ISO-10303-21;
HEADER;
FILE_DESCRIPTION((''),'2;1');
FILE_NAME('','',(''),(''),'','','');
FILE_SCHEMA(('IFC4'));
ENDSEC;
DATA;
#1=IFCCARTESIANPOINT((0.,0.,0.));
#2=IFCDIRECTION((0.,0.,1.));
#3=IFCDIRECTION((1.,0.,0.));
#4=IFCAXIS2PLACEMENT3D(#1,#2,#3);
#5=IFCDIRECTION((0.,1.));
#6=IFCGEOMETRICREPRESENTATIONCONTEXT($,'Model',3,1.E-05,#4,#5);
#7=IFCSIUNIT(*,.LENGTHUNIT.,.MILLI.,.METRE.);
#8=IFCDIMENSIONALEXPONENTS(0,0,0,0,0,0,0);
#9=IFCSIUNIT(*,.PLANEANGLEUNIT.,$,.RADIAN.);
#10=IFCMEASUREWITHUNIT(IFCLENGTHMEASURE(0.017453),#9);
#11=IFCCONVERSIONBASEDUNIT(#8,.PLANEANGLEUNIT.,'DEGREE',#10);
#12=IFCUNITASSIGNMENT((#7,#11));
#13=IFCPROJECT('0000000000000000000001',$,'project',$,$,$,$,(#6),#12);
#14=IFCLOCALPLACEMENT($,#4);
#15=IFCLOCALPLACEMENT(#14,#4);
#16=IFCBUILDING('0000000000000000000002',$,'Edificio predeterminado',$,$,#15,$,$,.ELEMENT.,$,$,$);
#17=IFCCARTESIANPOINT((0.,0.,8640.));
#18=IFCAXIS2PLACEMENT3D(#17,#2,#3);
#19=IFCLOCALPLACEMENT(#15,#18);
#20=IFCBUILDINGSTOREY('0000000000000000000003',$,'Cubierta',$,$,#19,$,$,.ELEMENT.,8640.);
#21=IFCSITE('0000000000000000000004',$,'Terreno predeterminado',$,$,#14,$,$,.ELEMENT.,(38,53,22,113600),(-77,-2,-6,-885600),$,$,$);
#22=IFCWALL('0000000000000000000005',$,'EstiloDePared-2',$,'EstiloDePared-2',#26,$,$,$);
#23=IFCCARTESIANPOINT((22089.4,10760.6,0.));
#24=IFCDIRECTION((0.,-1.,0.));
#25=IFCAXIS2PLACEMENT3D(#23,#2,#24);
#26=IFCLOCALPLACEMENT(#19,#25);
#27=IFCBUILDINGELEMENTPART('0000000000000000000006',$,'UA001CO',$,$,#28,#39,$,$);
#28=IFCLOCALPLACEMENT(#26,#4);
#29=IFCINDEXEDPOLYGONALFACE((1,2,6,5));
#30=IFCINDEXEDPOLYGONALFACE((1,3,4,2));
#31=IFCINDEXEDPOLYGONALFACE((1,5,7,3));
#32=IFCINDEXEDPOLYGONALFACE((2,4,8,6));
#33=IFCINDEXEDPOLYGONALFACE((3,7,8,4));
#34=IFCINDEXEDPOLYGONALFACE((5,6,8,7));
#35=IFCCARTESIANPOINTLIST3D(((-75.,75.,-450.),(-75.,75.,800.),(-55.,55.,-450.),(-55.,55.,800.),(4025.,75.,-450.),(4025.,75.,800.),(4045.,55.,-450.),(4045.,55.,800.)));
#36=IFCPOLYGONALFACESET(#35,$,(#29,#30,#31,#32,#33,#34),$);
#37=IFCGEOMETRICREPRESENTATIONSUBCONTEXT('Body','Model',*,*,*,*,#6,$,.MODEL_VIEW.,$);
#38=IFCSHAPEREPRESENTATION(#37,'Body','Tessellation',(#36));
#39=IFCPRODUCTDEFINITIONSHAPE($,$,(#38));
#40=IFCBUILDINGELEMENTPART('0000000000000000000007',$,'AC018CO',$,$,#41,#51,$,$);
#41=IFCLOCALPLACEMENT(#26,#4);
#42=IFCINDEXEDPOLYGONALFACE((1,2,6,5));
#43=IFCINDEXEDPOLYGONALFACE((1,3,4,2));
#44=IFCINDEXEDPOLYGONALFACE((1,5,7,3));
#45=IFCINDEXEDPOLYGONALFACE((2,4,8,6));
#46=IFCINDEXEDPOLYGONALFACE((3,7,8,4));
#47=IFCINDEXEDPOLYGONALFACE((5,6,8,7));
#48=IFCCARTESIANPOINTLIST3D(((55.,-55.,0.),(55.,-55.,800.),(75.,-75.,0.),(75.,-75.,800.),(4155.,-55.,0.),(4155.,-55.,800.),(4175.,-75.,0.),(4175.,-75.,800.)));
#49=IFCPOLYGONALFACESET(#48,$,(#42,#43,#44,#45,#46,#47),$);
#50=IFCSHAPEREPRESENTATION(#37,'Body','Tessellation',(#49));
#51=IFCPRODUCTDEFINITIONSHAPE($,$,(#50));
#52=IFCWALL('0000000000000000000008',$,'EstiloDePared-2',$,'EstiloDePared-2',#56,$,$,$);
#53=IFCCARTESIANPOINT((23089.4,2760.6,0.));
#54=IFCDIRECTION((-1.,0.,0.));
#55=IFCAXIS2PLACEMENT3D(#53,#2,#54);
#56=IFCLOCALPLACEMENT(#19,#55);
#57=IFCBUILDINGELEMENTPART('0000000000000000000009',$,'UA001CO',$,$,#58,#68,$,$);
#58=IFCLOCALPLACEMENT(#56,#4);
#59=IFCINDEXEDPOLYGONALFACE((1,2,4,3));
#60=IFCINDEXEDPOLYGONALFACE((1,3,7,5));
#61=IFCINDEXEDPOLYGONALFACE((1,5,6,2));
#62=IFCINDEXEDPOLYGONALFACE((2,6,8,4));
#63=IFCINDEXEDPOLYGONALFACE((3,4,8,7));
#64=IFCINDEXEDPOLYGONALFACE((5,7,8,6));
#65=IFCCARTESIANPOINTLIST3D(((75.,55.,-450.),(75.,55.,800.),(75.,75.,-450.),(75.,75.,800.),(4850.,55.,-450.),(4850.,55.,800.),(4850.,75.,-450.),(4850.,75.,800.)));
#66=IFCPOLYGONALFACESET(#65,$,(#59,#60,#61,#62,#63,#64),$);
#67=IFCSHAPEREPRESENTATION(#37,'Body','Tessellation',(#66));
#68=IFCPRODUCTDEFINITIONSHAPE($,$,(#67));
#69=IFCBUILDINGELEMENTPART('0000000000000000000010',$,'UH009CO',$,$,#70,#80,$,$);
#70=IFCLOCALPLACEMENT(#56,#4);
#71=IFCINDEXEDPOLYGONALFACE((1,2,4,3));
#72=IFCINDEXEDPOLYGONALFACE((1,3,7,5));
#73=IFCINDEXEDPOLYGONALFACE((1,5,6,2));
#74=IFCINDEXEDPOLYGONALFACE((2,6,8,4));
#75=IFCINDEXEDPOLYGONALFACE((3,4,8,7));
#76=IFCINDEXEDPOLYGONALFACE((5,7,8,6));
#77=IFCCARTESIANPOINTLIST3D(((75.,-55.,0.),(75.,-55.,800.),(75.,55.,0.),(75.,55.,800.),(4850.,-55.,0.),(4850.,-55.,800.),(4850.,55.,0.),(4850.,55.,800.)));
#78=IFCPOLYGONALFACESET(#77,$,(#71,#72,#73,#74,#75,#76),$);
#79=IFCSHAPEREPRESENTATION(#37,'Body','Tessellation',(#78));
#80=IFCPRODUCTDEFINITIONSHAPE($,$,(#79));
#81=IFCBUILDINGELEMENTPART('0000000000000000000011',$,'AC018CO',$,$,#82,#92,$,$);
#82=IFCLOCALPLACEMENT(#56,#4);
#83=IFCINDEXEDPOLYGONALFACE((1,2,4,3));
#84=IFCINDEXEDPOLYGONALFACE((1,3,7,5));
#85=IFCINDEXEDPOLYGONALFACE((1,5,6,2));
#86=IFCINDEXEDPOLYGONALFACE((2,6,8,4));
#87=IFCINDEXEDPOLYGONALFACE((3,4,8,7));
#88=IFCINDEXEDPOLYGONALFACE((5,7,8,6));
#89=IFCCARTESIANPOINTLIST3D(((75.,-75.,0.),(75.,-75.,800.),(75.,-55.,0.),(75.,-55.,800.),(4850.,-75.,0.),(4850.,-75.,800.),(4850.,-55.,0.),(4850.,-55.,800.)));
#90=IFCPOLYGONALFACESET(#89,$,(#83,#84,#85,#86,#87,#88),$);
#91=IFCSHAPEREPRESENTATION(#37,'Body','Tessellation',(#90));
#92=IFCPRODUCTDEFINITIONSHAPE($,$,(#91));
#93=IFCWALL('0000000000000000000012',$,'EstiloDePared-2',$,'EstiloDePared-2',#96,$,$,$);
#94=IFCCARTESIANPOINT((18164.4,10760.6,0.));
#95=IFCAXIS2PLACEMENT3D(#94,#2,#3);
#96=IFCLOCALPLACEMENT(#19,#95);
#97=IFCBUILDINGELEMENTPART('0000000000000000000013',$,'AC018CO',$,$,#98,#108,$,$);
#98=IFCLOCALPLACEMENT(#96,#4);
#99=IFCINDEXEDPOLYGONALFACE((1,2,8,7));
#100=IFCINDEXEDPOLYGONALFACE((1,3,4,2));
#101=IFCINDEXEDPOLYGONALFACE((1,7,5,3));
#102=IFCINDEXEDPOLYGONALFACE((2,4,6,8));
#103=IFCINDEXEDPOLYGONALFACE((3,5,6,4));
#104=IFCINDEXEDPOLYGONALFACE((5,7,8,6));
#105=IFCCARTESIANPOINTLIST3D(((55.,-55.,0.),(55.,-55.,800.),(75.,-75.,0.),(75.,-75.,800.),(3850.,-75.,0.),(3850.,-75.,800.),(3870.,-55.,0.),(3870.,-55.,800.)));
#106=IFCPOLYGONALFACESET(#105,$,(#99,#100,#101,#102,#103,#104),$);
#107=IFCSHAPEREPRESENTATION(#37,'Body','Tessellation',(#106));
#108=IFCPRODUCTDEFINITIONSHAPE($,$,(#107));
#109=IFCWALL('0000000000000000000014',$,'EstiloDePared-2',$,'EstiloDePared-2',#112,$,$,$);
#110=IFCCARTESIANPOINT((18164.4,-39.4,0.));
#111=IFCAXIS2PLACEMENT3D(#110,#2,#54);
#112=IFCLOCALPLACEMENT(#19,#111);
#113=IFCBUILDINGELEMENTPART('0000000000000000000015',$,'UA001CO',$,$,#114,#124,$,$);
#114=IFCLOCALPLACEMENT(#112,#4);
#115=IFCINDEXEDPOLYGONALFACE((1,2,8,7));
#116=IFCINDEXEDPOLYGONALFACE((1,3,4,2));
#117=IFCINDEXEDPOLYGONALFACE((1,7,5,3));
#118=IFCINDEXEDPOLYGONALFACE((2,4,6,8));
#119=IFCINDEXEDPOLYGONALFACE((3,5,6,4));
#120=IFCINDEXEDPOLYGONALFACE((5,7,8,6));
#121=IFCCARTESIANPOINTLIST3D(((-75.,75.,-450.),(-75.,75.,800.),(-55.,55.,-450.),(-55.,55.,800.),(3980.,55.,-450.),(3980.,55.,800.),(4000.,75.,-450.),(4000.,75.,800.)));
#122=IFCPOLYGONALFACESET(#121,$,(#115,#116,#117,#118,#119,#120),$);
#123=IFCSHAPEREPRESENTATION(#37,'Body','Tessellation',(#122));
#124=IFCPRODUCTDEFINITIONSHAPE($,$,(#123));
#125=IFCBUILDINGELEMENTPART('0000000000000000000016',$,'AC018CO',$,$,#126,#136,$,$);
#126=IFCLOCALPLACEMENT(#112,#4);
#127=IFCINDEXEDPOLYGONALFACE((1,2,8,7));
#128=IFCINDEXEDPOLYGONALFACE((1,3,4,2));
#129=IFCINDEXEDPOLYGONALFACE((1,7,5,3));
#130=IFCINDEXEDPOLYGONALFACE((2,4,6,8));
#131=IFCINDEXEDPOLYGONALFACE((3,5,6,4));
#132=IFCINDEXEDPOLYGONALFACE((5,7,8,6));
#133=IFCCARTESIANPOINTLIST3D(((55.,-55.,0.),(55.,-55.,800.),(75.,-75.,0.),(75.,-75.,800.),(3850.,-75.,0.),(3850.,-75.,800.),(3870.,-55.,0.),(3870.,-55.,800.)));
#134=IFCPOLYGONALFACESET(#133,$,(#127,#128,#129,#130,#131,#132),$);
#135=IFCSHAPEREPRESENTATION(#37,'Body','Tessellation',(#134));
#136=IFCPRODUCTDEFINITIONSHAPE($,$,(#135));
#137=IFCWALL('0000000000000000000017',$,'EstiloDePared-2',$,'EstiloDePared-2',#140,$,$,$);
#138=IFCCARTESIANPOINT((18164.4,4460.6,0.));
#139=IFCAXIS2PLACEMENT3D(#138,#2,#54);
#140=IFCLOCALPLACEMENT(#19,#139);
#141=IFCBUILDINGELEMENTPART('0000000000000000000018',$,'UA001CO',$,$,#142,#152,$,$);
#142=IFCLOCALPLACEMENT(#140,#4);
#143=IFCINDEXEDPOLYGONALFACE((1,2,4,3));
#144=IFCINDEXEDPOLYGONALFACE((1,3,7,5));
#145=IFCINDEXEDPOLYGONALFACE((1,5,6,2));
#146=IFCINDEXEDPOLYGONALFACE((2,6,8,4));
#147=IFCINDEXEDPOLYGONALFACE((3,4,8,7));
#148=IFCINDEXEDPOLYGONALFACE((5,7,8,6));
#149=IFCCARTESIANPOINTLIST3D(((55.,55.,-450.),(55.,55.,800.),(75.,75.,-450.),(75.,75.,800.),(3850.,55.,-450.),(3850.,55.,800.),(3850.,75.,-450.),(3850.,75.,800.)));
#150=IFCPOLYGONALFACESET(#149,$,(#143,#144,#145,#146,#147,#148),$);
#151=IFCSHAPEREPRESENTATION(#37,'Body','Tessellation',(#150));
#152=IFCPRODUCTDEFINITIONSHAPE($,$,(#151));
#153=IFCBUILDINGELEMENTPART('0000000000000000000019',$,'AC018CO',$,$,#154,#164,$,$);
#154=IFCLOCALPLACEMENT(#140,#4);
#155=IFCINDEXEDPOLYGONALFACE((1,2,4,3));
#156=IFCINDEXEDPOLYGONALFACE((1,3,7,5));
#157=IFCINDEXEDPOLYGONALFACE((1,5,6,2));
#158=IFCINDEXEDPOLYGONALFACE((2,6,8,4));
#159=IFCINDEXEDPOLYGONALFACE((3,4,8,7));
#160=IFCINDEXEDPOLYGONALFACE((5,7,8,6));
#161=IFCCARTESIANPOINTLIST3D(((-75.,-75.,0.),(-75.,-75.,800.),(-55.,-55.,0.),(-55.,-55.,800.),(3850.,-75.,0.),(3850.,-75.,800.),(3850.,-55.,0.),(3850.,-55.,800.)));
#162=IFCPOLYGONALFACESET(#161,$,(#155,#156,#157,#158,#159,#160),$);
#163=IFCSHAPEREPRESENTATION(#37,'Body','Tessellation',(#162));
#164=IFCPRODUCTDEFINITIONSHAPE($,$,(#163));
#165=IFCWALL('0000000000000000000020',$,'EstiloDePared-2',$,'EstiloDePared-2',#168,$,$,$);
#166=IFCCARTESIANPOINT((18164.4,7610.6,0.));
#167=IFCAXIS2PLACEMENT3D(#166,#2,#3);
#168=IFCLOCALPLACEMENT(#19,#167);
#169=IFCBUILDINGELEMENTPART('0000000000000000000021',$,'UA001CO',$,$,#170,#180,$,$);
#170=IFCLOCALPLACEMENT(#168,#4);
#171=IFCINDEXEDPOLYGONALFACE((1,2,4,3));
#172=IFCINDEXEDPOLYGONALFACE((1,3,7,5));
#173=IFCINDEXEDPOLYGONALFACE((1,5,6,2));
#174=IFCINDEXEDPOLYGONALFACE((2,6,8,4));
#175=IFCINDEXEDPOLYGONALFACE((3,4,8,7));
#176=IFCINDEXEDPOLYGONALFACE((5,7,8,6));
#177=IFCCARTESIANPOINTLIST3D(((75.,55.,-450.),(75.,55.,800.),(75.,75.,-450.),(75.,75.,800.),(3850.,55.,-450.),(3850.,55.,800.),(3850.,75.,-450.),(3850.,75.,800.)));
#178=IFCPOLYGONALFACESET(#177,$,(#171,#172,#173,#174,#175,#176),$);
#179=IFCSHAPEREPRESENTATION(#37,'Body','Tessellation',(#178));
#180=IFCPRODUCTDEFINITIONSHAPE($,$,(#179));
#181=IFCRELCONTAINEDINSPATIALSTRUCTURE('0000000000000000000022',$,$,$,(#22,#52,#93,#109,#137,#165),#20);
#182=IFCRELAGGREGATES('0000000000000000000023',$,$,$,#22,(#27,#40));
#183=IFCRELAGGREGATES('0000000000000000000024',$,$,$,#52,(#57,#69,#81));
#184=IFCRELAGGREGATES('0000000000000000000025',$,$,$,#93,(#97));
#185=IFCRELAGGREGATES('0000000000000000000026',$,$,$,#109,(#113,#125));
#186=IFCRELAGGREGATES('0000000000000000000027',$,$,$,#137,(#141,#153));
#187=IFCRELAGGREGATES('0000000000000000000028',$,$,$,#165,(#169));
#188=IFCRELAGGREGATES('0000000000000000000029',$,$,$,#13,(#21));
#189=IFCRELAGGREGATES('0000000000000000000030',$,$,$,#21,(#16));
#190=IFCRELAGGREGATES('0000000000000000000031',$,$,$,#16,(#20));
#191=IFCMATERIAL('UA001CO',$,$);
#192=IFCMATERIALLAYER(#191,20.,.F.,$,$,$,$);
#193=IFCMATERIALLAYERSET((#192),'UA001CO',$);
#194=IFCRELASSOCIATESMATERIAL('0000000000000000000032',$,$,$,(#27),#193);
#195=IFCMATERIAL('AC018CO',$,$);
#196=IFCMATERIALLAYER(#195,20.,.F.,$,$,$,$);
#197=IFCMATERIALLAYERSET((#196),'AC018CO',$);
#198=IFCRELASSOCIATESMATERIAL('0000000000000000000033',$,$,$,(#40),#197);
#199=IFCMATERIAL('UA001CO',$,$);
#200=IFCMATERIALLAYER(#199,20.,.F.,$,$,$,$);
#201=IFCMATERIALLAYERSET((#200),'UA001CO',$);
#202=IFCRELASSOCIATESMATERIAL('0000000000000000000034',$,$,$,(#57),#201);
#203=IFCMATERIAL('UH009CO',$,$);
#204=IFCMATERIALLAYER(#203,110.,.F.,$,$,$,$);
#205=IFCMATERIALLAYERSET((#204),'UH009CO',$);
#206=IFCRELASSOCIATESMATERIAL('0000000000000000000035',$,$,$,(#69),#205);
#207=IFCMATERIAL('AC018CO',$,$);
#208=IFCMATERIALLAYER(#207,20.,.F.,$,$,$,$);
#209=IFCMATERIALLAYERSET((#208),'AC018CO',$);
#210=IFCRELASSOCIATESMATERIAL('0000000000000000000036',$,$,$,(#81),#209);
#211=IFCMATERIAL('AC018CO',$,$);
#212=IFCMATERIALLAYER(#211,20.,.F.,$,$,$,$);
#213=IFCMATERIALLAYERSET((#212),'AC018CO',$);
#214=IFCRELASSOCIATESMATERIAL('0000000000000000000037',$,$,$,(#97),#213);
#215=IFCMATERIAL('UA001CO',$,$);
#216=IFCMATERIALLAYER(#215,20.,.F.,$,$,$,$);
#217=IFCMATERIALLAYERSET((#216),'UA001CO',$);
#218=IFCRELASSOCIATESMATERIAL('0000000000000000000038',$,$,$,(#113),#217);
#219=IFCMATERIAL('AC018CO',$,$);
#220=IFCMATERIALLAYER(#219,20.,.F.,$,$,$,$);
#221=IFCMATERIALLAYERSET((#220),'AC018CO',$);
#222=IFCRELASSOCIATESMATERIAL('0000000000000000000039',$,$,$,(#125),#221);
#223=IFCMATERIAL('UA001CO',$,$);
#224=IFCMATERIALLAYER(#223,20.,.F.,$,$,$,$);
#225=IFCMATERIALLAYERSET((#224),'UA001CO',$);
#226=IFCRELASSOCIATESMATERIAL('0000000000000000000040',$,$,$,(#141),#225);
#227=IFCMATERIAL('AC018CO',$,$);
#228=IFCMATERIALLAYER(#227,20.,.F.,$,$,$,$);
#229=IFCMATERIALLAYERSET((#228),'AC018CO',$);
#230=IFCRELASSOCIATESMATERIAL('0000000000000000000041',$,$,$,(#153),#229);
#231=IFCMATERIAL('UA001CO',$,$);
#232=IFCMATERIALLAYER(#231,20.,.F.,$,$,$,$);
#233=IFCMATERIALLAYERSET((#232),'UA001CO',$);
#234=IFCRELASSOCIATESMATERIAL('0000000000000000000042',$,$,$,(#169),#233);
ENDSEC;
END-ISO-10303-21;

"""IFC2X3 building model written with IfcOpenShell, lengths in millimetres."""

from ifc_helpers import new_model, entity, si_unit, converted_unit, direction, frame, origin_with_axes, place, context, subcontext, project, spatial, polyline, outline, extrude, material, layer, layer_set, layer_usage, element, aggregate, save


model = new_model("IFC2X3")

# Units and contexts
model_context = context("Model", 3, precision=1e-05, world=origin_with_axes(), true_north=direction((0.0, 1.0)))
body_context = subcontext(model_context, "Body", "Model", "MODEL_VIEW")
ifc_project = project(units=[si_unit("LENGTHUNIT", "METRE", prefix="MILLI"), converted_unit("PLANEANGLEUNIT", "DEGREE", entity("IfcLengthMeasure", 0.017453), si_unit("PLANEANGLEUNIT", "RADIAN"), dimensions=[0, 0, 0, 0, 0, 0, 0])], contexts=[model_context])

# Site, building, storey
site_placement = place(None, origin_with_axes())
site = spatial("IfcSite", under=ifc_project, at=site_placement, Name="Terreno predeterminado", CompositionType="ELEMENT", RefLatitude=(38, 53, 22, 113600), RefLongitude=(-77, -2, -6, -885600))
building_placement = place(site_placement, origin_with_axes())
building = spatial("IfcBuilding", under=site, at=building_placement, Name="Edificio predeterminado", CompositionType="ELEMENT")
storey_placement = place(building_placement, frame((0.0, 0.0, 8640.0), z_axis=(0.0, 0.0, 1.0), x_axis=(1.0, 0.0, 0.0)))
storey = spatial("IfcBuildingStorey", under=building, at=storey_placement, Name="Cubierta", CompositionType="ELEMENT", Elevation=8640.0)

# Walls, building element parts
wall_1_placement = place(storey_placement, frame((22089.4, 10760.6, 0.0), z_axis=(0.0, 0.0, 1.0), x_axis=(0.0, -1.0, 0.0)))
wall_1 = element("IfcWall", 1, at=wall_1_placement, inside=storey, Name="EstiloDePared-2", ObjectType="EstiloDePared-2")
ifc_material_1 = material(Name="UA001CO")
ifc_layer_1 = layer(ifc_material_1, 20.0, ventilated=False)
ifc_layer_set_1 = layer_set([ifc_layer_1], Name="UA001CO")
ifc_layer_usage_1 = layer_usage(ifc_layer_set_1, "AXIS2", "NEGATIVE", -75.0)
building_element_part_1_placement = place(wall_1_placement, origin_with_axes())
building_element_part_1 = element("IfcBuildingElementPart", 2, at=building_element_part_1_placement, material=ifc_layer_usage_1, Name="UA001CO", context=body_context, shape_type="SweptSolid", body=[
    extrude(outline(polyline([(4025.0, 75.0), (4045.0, 55.0), (-55.0, 55.0), (-75.0, 75.0), (4025.0, 75.0)])), frame((0.0, 0.0, -450.0), z_axis=(0.0, 0.0, 1.0), x_axis=(1.0, 0.0, 0.0)), (0.0, 0.0, 1.0), 1250.0),
])
ifc_material_2 = material(Name="AC018CO")
ifc_layer_2 = layer(ifc_material_2, 20.0, ventilated=False)
ifc_layer_set_2 = layer_set([ifc_layer_2], Name="AC018CO")
ifc_layer_usage_2 = layer_usage(ifc_layer_set_2, "AXIS2", "NEGATIVE", 55.0)
building_element_part_2_placement = place(wall_1_placement, origin_with_axes())
building_element_part_2 = element("IfcBuildingElementPart", 3, at=building_element_part_2_placement, material=ifc_layer_usage_2, Name="AC018CO", context=body_context, shape_type="SweptSolid", body=[
    extrude(outline(polyline([(4155.0, -55.0), (4175.0, -75.0), (75.0, -75.0), (55.0, -55.0), (4155.0, -55.0)])), origin_with_axes(), (0.0, 0.0, 1.0), 800.0),
])
aggregate(wall_1, [building_element_part_1, building_element_part_2])
wall_2_placement = place(storey_placement, frame((23089.4, 2760.6, 0.0), z_axis=(0.0, 0.0, 1.0), x_axis=(-1.0, 0.0, 0.0)))
wall_2 = element("IfcWall", 4, at=wall_2_placement, inside=storey, Name="EstiloDePared-2", ObjectType="EstiloDePared-2")
ifc_material_3 = material(Name="UA001CO")
ifc_layer_3 = layer(ifc_material_3, 20.0, ventilated=False)
ifc_layer_set_3 = layer_set([ifc_layer_3], Name="UA001CO")
ifc_layer_usage_3 = layer_usage(ifc_layer_set_3, "AXIS2", "NEGATIVE", -75.0)
building_element_part_3_placement = place(wall_2_placement, origin_with_axes())
building_element_part_3 = element("IfcBuildingElementPart", 5, at=building_element_part_3_placement, material=ifc_layer_usage_3, Name="UA001CO", context=body_context, shape_type="SweptSolid", body=[
    extrude(outline(polyline([(4850.0, 75.0), (4850.0, 55.0), (75.0, 55.0), (75.0, 75.0), (4850.0, 75.0)])), frame((0.0, 0.0, -450.0), z_axis=(0.0, 0.0, 1.0), x_axis=(1.0, 0.0, 0.0)), (0.0, 0.0, 1.0), 1250.0),
])
ifc_material_4 = material(Name="UH009CO")
ifc_layer_4 = layer(ifc_material_4, 110.0, ventilated=False)
ifc_layer_set_4 = layer_set([ifc_layer_4], Name="UH009CO")
ifc_layer_usage_4 = layer_usage(ifc_layer_set_4, "AXIS2", "NEGATIVE", -55.0)
building_element_part_4_placement = place(wall_2_placement, origin_with_axes())
building_element_part_4 = element("IfcBuildingElementPart", 6, at=building_element_part_4_placement, material=ifc_layer_usage_4, Name="UH009CO", context=body_context, shape_type="SweptSolid", body=[
    extrude(outline(polyline([(4850.0, 55.0), (4850.0, -55.0), (75.0, -55.0), (75.0, 55.0), (4850.0, 55.0)])), origin_with_axes(), (0.0, 0.0, 1.0), 800.0),
])
ifc_material_5 = material(Name="AC018CO")
ifc_layer_5 = layer(ifc_material_5, 20.0, ventilated=False)
ifc_layer_set_5 = layer_set([ifc_layer_5], Name="AC018CO")
ifc_layer_usage_5 = layer_usage(ifc_layer_set_5, "AXIS2", "NEGATIVE", 55.0)
building_element_part_5_placement = place(wall_2_placement, origin_with_axes())
building_element_part_5 = element("IfcBuildingElementPart", 7, at=building_element_part_5_placement, material=ifc_layer_usage_5, Name="AC018CO", context=body_context, shape_type="SweptSolid", body=[
    extrude(outline(polyline([(4850.0, -55.0), (4850.0, -75.0), (75.0, -75.0), (75.0, -55.0), (4850.0, -55.0)])), origin_with_axes(), (0.0, 0.0, 1.0), 800.0),
])
aggregate(wall_2, [building_element_part_3, building_element_part_4, building_element_part_5])

# Wall, building element part
wall_3_placement = place(storey_placement, frame((18164.4, 10760.6, 0.0), z_axis=(0.0, 0.0, 1.0), x_axis=(1.0, 0.0, 0.0)))
wall_3 = element("IfcWall", 8, at=wall_3_placement, inside=storey, Name="EstiloDePared-2", ObjectType="EstiloDePared-2")
ifc_material_6 = material(Name="AC018CO")
ifc_layer_6 = layer(ifc_material_6, 20.0, ventilated=False)
ifc_layer_set_6 = layer_set([ifc_layer_6], Name="AC018CO")
ifc_layer_usage_6 = layer_usage(ifc_layer_set_6, "AXIS2", "NEGATIVE", 55.0)
building_element_part_6_placement = place(wall_3_placement, origin_with_axes())
building_element_part_6 = element("IfcBuildingElementPart", 9, at=building_element_part_6_placement, material=ifc_layer_usage_6, Name="AC018CO", context=body_context, shape_type="SweptSolid", body=[
    extrude(outline(polyline([(3870.0, -55.0), (3850.0, -75.0), (75.0, -75.0), (55.0, -55.0), (3870.0, -55.0)])), origin_with_axes(), (0.0, 0.0, 1.0), 800.0),
])
aggregate(wall_3, [building_element_part_6])

# Walls, building element parts
wall_4_placement = place(storey_placement, frame((18164.4, -39.4, 0.0), z_axis=(0.0, 0.0, 1.0), x_axis=(-1.0, 0.0, 0.0)))
wall_4 = element("IfcWall", 10, at=wall_4_placement, inside=storey, Name="EstiloDePared-2", ObjectType="EstiloDePared-2")
ifc_material_7 = material(Name="UA001CO")
ifc_layer_7 = layer(ifc_material_7, 20.0, ventilated=False)
ifc_layer_set_7 = layer_set([ifc_layer_7], Name="UA001CO")
ifc_layer_usage_7 = layer_usage(ifc_layer_set_7, "AXIS2", "NEGATIVE", -75.0)
building_element_part_7_placement = place(wall_4_placement, origin_with_axes())
building_element_part_7 = element("IfcBuildingElementPart", 11, at=building_element_part_7_placement, material=ifc_layer_usage_7, Name="UA001CO", context=body_context, shape_type="SweptSolid", body=[
    extrude(outline(polyline([(4000.0, 75.0), (3980.0, 55.0), (-55.0, 55.0), (-75.0, 75.0), (4000.0, 75.0)])), frame((0.0, 0.0, -450.0), z_axis=(0.0, 0.0, 1.0), x_axis=(1.0, 0.0, 0.0)), (0.0, 0.0, 1.0), 1250.0),
])
ifc_material_8 = material(Name="AC018CO")
ifc_layer_8 = layer(ifc_material_8, 20.0, ventilated=False)
ifc_layer_set_8 = layer_set([ifc_layer_8], Name="AC018CO")
ifc_layer_usage_8 = layer_usage(ifc_layer_set_8, "AXIS2", "NEGATIVE", 55.0)
building_element_part_8_placement = place(wall_4_placement, origin_with_axes())
building_element_part_8 = element("IfcBuildingElementPart", 12, at=building_element_part_8_placement, material=ifc_layer_usage_8, Name="AC018CO", context=body_context, shape_type="SweptSolid", body=[
    extrude(outline(polyline([(3870.0, -55.0), (3850.0, -75.0), (75.0, -75.0), (55.0, -55.0), (3870.0, -55.0)])), origin_with_axes(), (0.0, 0.0, 1.0), 800.0),
])
aggregate(wall_4, [building_element_part_7, building_element_part_8])
wall_5_placement = place(storey_placement, frame((18164.4, 4460.6, 0.0), z_axis=(0.0, 0.0, 1.0), x_axis=(-1.0, 0.0, 0.0)))
wall_5 = element("IfcWall", 13, at=wall_5_placement, inside=storey, Name="EstiloDePared-2", ObjectType="EstiloDePared-2")
ifc_material_9 = material(Name="UA001CO")
ifc_layer_9 = layer(ifc_material_9, 20.0, ventilated=False)
ifc_layer_set_9 = layer_set([ifc_layer_9], Name="UA001CO")
ifc_layer_usage_9 = layer_usage(ifc_layer_set_9, "AXIS2", "NEGATIVE", -75.0)
building_element_part_9_placement = place(wall_5_placement, origin_with_axes())
building_element_part_9 = element("IfcBuildingElementPart", 14, at=building_element_part_9_placement, material=ifc_layer_usage_9, Name="UA001CO", context=body_context, shape_type="SweptSolid", body=[
    extrude(outline(polyline([(3850.0, 75.0), (3850.0, 55.0), (55.0, 55.0), (75.0, 75.0), (3850.0, 75.0)])), frame((0.0, 0.0, -450.0), z_axis=(0.0, 0.0, 1.0), x_axis=(1.0, 0.0, 0.0)), (0.0, 0.0, 1.0), 1250.0),
])
ifc_material_10 = material(Name="AC018CO")
ifc_layer_10 = layer(ifc_material_10, 20.0, ventilated=False)
ifc_layer_set_10 = layer_set([ifc_layer_10], Name="AC018CO")
ifc_layer_usage_10 = layer_usage(ifc_layer_set_10, "AXIS2", "NEGATIVE", 55.0)
building_element_part_10_placement = place(wall_5_placement, origin_with_axes())
building_element_part_10 = element("IfcBuildingElementPart", 15, at=building_element_part_10_placement, material=ifc_layer_usage_10, Name="AC018CO", context=body_context, shape_type="SweptSolid", body=[
    extrude(outline(polyline([(3850.0, -55.0), (3850.0, -75.0), (-75.0, -75.0), (-55.0, -55.0), (3850.0, -55.0)])), origin_with_axes(), (0.0, 0.0, 1.0), 800.0),
])
aggregate(wall_5, [building_element_part_9, building_element_part_10])
wall_6_placement = place(storey_placement, frame((18164.4, 7610.6, 0.0), z_axis=(0.0, 0.0, 1.0), x_axis=(1.0, 0.0, 0.0)))
wall_6 = element("IfcWall", 16, at=wall_6_placement, inside=storey, Name="EstiloDePared-2", ObjectType="EstiloDePared-2")
ifc_material_11 = material(Name="UA001CO")
ifc_layer_11 = layer(ifc_material_11, 20.0, ventilated=False)
ifc_layer_set_11 = layer_set([ifc_layer_11], Name="UA001CO")
ifc_layer_usage_11 = layer_usage(ifc_layer_set_11, "AXIS2", "NEGATIVE", -75.0)
building_element_part_11_placement = place(wall_6_placement, origin_with_axes())
building_element_part_11 = element("IfcBuildingElementPart", 17, at=building_element_part_11_placement, material=ifc_layer_usage_11, Name="UA001CO", context=body_context, shape_type="SweptSolid", body=[
    extrude(outline(polyline([(3850.0, 75.0), (3850.0, 55.0), (75.0, 55.0), (75.0, 75.0), (3850.0, 75.0)])), frame((0.0, 0.0, -450.0), z_axis=(0.0, 0.0, 1.0), x_axis=(1.0, 0.0, 0.0)), (0.0, 0.0, 1.0), 1250.0),
])
aggregate(wall_6, [building_element_part_11])

save(model, "model.ifc")
